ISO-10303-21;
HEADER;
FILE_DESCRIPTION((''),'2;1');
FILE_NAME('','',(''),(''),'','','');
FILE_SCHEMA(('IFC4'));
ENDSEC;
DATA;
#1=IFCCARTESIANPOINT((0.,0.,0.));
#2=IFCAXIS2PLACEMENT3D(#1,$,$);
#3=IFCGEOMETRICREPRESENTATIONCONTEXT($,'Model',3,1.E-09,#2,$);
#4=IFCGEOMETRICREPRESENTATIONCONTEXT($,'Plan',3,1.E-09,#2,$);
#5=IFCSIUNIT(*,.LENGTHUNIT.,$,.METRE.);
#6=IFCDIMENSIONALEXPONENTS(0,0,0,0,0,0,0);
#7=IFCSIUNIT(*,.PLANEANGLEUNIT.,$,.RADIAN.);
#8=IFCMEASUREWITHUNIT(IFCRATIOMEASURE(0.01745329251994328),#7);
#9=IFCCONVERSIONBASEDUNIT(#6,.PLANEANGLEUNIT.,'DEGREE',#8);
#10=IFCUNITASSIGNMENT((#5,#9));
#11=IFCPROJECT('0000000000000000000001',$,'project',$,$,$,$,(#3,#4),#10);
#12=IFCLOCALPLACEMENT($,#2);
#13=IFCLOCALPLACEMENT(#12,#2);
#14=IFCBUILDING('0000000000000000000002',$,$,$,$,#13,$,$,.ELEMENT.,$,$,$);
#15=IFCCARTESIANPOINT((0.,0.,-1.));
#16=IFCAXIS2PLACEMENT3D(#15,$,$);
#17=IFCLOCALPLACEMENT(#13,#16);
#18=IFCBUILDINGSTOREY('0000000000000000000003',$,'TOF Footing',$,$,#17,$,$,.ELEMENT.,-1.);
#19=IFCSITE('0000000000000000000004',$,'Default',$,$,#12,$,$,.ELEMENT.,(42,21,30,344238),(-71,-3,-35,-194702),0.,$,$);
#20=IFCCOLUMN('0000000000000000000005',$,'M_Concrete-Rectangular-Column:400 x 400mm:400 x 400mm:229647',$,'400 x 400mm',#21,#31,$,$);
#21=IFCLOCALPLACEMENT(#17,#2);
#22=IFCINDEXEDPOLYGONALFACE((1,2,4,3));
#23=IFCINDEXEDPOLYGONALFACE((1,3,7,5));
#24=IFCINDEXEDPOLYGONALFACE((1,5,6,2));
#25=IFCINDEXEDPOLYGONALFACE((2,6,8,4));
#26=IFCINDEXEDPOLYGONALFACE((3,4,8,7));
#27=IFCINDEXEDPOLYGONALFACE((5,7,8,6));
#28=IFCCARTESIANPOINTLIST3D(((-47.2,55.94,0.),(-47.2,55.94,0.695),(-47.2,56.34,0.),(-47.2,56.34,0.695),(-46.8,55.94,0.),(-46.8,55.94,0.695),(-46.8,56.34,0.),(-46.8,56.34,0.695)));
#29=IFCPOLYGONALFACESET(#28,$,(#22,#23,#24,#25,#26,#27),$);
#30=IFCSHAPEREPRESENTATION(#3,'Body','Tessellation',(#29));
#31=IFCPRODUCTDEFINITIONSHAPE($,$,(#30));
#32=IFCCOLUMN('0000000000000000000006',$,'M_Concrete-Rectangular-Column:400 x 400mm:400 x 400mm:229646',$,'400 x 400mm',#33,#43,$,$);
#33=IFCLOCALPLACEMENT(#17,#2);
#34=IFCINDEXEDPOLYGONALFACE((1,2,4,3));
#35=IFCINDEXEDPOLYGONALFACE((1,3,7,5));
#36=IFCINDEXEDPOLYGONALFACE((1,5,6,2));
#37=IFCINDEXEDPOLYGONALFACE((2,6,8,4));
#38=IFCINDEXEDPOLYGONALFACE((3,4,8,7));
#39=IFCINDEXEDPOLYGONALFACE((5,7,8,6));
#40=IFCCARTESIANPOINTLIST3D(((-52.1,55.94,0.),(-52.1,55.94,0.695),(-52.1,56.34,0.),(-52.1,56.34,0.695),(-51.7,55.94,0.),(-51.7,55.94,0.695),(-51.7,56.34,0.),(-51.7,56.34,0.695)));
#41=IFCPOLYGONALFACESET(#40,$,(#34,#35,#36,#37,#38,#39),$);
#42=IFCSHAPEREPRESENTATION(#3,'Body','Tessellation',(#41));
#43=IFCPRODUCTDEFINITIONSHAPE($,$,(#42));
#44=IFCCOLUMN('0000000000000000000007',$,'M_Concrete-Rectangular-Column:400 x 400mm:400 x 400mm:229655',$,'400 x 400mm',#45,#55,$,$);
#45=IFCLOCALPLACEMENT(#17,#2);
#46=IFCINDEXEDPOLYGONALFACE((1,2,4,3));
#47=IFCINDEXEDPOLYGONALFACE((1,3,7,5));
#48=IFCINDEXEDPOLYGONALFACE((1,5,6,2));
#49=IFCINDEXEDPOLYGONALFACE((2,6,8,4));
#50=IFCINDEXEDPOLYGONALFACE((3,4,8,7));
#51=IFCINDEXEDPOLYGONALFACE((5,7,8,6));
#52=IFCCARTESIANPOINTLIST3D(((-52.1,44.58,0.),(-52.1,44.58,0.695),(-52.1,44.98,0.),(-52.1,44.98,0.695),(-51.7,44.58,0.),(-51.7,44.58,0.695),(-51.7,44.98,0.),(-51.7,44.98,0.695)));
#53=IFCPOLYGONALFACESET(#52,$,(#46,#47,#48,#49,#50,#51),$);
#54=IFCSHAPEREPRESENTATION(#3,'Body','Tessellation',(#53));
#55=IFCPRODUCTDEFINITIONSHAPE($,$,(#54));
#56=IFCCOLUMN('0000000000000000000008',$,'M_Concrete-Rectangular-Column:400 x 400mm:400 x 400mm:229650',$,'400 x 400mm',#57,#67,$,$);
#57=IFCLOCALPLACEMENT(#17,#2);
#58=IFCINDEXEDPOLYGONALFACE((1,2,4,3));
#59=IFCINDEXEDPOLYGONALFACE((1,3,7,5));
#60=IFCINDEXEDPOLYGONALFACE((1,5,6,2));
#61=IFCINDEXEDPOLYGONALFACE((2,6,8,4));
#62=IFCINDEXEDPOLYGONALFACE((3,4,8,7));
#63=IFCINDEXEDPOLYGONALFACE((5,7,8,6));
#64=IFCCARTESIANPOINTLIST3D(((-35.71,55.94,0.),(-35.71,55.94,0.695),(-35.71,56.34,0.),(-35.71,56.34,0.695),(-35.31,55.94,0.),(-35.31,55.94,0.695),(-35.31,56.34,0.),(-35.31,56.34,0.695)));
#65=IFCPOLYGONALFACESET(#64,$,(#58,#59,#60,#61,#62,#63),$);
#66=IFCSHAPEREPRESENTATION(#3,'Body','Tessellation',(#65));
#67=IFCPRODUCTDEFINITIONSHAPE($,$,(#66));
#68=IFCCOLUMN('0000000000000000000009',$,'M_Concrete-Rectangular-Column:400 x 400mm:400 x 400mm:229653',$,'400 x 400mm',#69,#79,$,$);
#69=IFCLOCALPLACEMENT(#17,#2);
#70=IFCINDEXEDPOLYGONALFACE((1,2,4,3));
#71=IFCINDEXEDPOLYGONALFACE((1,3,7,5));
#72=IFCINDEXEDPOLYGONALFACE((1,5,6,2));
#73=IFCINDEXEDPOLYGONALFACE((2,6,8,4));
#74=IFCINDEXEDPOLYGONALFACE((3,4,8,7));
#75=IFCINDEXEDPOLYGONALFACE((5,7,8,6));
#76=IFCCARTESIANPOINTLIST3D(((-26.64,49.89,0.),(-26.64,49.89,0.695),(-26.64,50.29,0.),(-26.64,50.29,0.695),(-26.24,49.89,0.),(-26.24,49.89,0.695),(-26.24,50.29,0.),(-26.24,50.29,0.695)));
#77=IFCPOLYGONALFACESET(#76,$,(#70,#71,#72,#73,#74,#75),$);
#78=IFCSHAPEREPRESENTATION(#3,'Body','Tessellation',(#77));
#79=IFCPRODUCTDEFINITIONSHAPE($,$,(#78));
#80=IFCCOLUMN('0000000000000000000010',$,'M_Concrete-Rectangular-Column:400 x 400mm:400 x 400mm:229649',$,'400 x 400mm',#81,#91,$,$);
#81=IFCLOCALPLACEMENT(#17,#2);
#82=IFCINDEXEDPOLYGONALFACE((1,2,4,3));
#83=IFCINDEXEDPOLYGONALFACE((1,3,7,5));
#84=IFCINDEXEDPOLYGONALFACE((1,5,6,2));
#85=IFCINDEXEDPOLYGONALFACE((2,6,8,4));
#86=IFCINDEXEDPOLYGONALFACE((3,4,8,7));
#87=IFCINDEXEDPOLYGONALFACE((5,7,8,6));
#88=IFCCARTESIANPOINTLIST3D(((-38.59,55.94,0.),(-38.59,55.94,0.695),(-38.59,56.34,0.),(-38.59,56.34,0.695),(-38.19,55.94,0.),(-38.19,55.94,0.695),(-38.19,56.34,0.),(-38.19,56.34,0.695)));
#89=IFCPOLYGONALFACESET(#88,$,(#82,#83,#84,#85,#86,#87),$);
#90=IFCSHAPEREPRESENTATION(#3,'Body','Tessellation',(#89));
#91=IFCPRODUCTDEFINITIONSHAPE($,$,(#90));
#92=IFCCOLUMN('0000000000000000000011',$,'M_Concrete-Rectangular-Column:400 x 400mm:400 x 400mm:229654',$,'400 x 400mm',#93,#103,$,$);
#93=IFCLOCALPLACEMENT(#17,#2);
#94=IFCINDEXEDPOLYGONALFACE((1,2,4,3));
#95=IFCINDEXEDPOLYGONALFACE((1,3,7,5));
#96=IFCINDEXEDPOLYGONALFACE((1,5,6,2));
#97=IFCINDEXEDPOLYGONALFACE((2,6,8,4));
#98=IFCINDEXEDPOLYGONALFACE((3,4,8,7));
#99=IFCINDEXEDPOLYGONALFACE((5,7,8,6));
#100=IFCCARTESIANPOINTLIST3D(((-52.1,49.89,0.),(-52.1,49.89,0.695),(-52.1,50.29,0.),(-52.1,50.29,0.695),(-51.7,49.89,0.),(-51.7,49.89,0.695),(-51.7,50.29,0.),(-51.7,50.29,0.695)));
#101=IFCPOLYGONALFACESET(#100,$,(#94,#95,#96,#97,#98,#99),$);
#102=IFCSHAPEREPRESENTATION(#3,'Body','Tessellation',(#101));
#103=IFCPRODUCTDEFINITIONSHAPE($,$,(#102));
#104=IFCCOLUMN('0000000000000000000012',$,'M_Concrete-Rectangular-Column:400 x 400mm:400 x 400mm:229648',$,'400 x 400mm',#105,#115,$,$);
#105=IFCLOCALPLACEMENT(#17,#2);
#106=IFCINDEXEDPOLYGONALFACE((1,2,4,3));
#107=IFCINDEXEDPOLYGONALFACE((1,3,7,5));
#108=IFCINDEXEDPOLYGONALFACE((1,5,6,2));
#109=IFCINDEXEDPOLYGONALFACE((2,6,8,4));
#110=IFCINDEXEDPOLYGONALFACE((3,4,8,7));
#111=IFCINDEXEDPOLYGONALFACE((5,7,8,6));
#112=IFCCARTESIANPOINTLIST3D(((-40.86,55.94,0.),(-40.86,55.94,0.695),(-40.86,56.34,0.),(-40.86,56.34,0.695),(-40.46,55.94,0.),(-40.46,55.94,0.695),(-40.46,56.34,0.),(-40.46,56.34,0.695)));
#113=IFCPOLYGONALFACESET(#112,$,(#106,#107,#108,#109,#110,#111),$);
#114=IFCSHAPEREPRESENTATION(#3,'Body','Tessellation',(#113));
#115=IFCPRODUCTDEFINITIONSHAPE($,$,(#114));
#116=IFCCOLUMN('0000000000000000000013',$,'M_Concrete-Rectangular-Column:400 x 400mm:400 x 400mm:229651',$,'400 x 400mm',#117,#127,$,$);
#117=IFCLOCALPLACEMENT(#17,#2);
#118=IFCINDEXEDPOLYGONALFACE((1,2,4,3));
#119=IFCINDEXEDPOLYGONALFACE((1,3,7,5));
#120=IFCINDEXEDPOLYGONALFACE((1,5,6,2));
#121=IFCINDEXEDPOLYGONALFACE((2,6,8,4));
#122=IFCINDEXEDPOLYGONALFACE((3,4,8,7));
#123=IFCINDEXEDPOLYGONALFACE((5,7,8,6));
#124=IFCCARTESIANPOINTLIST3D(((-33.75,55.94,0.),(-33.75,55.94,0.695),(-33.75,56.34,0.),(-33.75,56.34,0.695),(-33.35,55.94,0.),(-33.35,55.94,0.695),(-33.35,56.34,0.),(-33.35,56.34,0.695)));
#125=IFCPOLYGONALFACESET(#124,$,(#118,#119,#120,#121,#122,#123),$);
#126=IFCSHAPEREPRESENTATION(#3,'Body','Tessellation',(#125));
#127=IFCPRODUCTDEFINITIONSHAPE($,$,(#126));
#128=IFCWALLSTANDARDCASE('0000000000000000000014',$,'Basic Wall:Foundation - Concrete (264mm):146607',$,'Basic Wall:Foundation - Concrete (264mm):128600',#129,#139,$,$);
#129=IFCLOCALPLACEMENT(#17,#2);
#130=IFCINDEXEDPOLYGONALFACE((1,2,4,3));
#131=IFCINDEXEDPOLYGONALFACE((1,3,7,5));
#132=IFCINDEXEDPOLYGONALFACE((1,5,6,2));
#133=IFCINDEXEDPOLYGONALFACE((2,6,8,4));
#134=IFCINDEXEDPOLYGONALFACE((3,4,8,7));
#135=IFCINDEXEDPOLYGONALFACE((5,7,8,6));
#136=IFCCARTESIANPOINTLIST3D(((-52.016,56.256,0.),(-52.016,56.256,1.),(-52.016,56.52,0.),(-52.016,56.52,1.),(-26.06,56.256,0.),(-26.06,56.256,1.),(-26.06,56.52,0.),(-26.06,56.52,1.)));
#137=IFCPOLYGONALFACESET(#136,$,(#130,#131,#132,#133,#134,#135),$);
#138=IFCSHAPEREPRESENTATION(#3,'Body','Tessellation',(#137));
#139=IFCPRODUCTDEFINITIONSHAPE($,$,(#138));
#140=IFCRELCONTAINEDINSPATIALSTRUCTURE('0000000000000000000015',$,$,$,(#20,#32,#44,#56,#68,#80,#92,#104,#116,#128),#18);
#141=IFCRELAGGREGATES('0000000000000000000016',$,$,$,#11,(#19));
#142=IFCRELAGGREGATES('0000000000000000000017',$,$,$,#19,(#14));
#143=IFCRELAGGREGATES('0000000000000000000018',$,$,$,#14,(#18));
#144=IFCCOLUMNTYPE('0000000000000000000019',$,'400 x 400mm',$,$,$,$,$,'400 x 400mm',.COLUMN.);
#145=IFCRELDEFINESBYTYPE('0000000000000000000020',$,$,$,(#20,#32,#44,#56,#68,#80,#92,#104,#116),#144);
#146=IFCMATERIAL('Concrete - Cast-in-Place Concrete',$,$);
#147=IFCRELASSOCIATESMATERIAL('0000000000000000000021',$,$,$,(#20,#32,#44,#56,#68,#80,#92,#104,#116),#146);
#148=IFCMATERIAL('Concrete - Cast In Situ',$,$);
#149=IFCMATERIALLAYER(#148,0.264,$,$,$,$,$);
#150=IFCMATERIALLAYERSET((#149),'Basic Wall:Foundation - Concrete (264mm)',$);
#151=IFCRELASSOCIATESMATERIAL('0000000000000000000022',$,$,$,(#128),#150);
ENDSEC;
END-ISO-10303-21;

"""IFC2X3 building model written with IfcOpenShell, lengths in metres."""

from ifc_helpers import new_model, entity, si_unit, converted_unit, frame, frame_2d, origin, place, context, project, spatial, rectangle, extrude, source, transform, mapped, material, layer, layer_set, layer_usage, type_object, type_shapes, element, save


model = new_model("IFC2X3")

# Units and contexts
model_context = context("Model", 3, precision=1e-09, world=origin())
plan_context = context("Plan", 3, precision=1e-09, world=origin())
ifc_project = project(units=[si_unit("LENGTHUNIT", "METRE"), converted_unit("PLANEANGLEUNIT", "DEGREE", entity("IfcRatioMeasure", 0.01745329251994328), si_unit("PLANEANGLEUNIT", "RADIAN"), dimensions=[0, 0, 0, 0, 0, 0, 0])], contexts=[model_context, plan_context])

# Site, building, storey
site_placement = place(None, origin())
site = spatial("IfcSite", under=ifc_project, at=site_placement, Name="Default", CompositionType="ELEMENT", RefLatitude=(42, 21, 30, 344238), RefLongitude=(-71, -3, -35, -194702), RefElevation=0.0)
building_placement = place(site_placement, origin())
building = spatial("IfcBuilding", under=site, at=building_placement, CompositionType="ELEMENT")
storey_placement = place(building_placement, frame((0.0, 0.0, -1.0)))
storey = spatial("IfcBuildingStorey", under=building, at=storey_placement, Name="TOF Footing", CompositionType="ELEMENT", Elevation=-1.0)

# Columns
ifc_material_1 = material(Name="Concrete - Cast-in-Place Concrete")
column_type_1 = type_object("IfcColumnType", Name="400 x 400mm", ElementType="400 x 400mm", PredefinedType="COLUMN")
shared_shape_1 = source(origin(), model_context, "Body", "SweptSolid", [
    extrude(rectangle(XDim=0.4, YDim=0.4, at=frame_2d((0.0, 0.0), x_axis=(0.0, -1.0))), origin(), (0.0, 0.0, 1.0), 0.695),
])
type_shapes(column_type_1, [shared_shape_1])
for number, where, z_axis, x_axis, name in (
    (1, (-47.0, 56.14, 0.0), (0.0, 0.0, 1.0), (0.0, 1.0, 0.0), "M_Concrete-Rectangular-Column:400 x 400mm:400 x 400mm:229647"),
    (2, (-51.9, 56.14, 0.0), (0.0, 0.0, 1.0), (0.0, 1.0, 0.0), "M_Concrete-Rectangular-Column:400 x 400mm:400 x 400mm:229646"),
    (3, (-51.9, 44.78, 0.0), (0.0, 0.0, 1.0), (0.0, -1.0, 0.0), "M_Concrete-Rectangular-Column:400 x 400mm:400 x 400mm:229655"),
    (4, (-35.51, 56.14, 0.0), (0.0, 0.0, 1.0), (0.0, 1.0, 0.0), "M_Concrete-Rectangular-Column:400 x 400mm:400 x 400mm:229650"),
    (5, (-26.44, 50.09, 0.0), (0.0, 0.0, 1.0), (0.0, 1.0, 0.0), "M_Concrete-Rectangular-Column:400 x 400mm:400 x 400mm:229653"),
    (6, (-38.39, 56.14, 0.0), (0.0, 0.0, 1.0), (0.0, 1.0, 0.0), "M_Concrete-Rectangular-Column:400 x 400mm:400 x 400mm:229649"),
    (7, (-51.9, 50.09, 0.0), (0.0, 0.0, 1.0), (0.0, -1.0, 0.0), "M_Concrete-Rectangular-Column:400 x 400mm:400 x 400mm:229654"),
    (8, (-40.66, 56.14, 0.0), (0.0, 0.0, 1.0), (0.0, 1.0, 0.0), "M_Concrete-Rectangular-Column:400 x 400mm:400 x 400mm:229648"),
    (9, (-33.55, 56.14, 0.0), (0.0, 0.0, 1.0), (0.0, 1.0, 0.0), "M_Concrete-Rectangular-Column:400 x 400mm:400 x 400mm:229651"),
):
    element("IfcColumn", number, at=place(storey_placement, frame(where, z_axis=z_axis, x_axis=x_axis)), inside=storey, type_object=column_type_1, material=ifc_material_1, Name=name, ObjectType="400 x 400mm", context=model_context, shape_type="MappedRepresentation", body=[
        mapped(shared_shape_1, transform((0.0, 0.0, 0.0), scale=1.0)),
    ])

# Wall
ifc_material_2 = material(Name="Concrete - Cast In Situ")
ifc_layer = layer(ifc_material_2, 0.264)
ifc_layer_set = layer_set([ifc_layer], Name="Basic Wall:Foundation - Concrete (264mm)")
ifc_layer_usage = layer_usage(ifc_layer_set, "AXIS2", "NEGATIVE", 0.132)
wall_placement = place(storey_placement, frame((-52.016, 56.388, 0.0)))
element("IfcWallStandardCase", 10, at=wall_placement, inside=storey, material=ifc_layer_usage, Name="Basic Wall:Foundation - Concrete (264mm):146607", ObjectType="Basic Wall:Foundation - Concrete (264mm):128600", context=model_context, shape_type="SweptSolid", body=[
    extrude(rectangle(XDim=25.956, YDim=0.264, at=frame_2d((12.978, 0.0), x_axis=(-1.0, 0.0))), origin(), (0.0, 0.0, 1.0), 1.0),
])

save(model, "model.ifc")
